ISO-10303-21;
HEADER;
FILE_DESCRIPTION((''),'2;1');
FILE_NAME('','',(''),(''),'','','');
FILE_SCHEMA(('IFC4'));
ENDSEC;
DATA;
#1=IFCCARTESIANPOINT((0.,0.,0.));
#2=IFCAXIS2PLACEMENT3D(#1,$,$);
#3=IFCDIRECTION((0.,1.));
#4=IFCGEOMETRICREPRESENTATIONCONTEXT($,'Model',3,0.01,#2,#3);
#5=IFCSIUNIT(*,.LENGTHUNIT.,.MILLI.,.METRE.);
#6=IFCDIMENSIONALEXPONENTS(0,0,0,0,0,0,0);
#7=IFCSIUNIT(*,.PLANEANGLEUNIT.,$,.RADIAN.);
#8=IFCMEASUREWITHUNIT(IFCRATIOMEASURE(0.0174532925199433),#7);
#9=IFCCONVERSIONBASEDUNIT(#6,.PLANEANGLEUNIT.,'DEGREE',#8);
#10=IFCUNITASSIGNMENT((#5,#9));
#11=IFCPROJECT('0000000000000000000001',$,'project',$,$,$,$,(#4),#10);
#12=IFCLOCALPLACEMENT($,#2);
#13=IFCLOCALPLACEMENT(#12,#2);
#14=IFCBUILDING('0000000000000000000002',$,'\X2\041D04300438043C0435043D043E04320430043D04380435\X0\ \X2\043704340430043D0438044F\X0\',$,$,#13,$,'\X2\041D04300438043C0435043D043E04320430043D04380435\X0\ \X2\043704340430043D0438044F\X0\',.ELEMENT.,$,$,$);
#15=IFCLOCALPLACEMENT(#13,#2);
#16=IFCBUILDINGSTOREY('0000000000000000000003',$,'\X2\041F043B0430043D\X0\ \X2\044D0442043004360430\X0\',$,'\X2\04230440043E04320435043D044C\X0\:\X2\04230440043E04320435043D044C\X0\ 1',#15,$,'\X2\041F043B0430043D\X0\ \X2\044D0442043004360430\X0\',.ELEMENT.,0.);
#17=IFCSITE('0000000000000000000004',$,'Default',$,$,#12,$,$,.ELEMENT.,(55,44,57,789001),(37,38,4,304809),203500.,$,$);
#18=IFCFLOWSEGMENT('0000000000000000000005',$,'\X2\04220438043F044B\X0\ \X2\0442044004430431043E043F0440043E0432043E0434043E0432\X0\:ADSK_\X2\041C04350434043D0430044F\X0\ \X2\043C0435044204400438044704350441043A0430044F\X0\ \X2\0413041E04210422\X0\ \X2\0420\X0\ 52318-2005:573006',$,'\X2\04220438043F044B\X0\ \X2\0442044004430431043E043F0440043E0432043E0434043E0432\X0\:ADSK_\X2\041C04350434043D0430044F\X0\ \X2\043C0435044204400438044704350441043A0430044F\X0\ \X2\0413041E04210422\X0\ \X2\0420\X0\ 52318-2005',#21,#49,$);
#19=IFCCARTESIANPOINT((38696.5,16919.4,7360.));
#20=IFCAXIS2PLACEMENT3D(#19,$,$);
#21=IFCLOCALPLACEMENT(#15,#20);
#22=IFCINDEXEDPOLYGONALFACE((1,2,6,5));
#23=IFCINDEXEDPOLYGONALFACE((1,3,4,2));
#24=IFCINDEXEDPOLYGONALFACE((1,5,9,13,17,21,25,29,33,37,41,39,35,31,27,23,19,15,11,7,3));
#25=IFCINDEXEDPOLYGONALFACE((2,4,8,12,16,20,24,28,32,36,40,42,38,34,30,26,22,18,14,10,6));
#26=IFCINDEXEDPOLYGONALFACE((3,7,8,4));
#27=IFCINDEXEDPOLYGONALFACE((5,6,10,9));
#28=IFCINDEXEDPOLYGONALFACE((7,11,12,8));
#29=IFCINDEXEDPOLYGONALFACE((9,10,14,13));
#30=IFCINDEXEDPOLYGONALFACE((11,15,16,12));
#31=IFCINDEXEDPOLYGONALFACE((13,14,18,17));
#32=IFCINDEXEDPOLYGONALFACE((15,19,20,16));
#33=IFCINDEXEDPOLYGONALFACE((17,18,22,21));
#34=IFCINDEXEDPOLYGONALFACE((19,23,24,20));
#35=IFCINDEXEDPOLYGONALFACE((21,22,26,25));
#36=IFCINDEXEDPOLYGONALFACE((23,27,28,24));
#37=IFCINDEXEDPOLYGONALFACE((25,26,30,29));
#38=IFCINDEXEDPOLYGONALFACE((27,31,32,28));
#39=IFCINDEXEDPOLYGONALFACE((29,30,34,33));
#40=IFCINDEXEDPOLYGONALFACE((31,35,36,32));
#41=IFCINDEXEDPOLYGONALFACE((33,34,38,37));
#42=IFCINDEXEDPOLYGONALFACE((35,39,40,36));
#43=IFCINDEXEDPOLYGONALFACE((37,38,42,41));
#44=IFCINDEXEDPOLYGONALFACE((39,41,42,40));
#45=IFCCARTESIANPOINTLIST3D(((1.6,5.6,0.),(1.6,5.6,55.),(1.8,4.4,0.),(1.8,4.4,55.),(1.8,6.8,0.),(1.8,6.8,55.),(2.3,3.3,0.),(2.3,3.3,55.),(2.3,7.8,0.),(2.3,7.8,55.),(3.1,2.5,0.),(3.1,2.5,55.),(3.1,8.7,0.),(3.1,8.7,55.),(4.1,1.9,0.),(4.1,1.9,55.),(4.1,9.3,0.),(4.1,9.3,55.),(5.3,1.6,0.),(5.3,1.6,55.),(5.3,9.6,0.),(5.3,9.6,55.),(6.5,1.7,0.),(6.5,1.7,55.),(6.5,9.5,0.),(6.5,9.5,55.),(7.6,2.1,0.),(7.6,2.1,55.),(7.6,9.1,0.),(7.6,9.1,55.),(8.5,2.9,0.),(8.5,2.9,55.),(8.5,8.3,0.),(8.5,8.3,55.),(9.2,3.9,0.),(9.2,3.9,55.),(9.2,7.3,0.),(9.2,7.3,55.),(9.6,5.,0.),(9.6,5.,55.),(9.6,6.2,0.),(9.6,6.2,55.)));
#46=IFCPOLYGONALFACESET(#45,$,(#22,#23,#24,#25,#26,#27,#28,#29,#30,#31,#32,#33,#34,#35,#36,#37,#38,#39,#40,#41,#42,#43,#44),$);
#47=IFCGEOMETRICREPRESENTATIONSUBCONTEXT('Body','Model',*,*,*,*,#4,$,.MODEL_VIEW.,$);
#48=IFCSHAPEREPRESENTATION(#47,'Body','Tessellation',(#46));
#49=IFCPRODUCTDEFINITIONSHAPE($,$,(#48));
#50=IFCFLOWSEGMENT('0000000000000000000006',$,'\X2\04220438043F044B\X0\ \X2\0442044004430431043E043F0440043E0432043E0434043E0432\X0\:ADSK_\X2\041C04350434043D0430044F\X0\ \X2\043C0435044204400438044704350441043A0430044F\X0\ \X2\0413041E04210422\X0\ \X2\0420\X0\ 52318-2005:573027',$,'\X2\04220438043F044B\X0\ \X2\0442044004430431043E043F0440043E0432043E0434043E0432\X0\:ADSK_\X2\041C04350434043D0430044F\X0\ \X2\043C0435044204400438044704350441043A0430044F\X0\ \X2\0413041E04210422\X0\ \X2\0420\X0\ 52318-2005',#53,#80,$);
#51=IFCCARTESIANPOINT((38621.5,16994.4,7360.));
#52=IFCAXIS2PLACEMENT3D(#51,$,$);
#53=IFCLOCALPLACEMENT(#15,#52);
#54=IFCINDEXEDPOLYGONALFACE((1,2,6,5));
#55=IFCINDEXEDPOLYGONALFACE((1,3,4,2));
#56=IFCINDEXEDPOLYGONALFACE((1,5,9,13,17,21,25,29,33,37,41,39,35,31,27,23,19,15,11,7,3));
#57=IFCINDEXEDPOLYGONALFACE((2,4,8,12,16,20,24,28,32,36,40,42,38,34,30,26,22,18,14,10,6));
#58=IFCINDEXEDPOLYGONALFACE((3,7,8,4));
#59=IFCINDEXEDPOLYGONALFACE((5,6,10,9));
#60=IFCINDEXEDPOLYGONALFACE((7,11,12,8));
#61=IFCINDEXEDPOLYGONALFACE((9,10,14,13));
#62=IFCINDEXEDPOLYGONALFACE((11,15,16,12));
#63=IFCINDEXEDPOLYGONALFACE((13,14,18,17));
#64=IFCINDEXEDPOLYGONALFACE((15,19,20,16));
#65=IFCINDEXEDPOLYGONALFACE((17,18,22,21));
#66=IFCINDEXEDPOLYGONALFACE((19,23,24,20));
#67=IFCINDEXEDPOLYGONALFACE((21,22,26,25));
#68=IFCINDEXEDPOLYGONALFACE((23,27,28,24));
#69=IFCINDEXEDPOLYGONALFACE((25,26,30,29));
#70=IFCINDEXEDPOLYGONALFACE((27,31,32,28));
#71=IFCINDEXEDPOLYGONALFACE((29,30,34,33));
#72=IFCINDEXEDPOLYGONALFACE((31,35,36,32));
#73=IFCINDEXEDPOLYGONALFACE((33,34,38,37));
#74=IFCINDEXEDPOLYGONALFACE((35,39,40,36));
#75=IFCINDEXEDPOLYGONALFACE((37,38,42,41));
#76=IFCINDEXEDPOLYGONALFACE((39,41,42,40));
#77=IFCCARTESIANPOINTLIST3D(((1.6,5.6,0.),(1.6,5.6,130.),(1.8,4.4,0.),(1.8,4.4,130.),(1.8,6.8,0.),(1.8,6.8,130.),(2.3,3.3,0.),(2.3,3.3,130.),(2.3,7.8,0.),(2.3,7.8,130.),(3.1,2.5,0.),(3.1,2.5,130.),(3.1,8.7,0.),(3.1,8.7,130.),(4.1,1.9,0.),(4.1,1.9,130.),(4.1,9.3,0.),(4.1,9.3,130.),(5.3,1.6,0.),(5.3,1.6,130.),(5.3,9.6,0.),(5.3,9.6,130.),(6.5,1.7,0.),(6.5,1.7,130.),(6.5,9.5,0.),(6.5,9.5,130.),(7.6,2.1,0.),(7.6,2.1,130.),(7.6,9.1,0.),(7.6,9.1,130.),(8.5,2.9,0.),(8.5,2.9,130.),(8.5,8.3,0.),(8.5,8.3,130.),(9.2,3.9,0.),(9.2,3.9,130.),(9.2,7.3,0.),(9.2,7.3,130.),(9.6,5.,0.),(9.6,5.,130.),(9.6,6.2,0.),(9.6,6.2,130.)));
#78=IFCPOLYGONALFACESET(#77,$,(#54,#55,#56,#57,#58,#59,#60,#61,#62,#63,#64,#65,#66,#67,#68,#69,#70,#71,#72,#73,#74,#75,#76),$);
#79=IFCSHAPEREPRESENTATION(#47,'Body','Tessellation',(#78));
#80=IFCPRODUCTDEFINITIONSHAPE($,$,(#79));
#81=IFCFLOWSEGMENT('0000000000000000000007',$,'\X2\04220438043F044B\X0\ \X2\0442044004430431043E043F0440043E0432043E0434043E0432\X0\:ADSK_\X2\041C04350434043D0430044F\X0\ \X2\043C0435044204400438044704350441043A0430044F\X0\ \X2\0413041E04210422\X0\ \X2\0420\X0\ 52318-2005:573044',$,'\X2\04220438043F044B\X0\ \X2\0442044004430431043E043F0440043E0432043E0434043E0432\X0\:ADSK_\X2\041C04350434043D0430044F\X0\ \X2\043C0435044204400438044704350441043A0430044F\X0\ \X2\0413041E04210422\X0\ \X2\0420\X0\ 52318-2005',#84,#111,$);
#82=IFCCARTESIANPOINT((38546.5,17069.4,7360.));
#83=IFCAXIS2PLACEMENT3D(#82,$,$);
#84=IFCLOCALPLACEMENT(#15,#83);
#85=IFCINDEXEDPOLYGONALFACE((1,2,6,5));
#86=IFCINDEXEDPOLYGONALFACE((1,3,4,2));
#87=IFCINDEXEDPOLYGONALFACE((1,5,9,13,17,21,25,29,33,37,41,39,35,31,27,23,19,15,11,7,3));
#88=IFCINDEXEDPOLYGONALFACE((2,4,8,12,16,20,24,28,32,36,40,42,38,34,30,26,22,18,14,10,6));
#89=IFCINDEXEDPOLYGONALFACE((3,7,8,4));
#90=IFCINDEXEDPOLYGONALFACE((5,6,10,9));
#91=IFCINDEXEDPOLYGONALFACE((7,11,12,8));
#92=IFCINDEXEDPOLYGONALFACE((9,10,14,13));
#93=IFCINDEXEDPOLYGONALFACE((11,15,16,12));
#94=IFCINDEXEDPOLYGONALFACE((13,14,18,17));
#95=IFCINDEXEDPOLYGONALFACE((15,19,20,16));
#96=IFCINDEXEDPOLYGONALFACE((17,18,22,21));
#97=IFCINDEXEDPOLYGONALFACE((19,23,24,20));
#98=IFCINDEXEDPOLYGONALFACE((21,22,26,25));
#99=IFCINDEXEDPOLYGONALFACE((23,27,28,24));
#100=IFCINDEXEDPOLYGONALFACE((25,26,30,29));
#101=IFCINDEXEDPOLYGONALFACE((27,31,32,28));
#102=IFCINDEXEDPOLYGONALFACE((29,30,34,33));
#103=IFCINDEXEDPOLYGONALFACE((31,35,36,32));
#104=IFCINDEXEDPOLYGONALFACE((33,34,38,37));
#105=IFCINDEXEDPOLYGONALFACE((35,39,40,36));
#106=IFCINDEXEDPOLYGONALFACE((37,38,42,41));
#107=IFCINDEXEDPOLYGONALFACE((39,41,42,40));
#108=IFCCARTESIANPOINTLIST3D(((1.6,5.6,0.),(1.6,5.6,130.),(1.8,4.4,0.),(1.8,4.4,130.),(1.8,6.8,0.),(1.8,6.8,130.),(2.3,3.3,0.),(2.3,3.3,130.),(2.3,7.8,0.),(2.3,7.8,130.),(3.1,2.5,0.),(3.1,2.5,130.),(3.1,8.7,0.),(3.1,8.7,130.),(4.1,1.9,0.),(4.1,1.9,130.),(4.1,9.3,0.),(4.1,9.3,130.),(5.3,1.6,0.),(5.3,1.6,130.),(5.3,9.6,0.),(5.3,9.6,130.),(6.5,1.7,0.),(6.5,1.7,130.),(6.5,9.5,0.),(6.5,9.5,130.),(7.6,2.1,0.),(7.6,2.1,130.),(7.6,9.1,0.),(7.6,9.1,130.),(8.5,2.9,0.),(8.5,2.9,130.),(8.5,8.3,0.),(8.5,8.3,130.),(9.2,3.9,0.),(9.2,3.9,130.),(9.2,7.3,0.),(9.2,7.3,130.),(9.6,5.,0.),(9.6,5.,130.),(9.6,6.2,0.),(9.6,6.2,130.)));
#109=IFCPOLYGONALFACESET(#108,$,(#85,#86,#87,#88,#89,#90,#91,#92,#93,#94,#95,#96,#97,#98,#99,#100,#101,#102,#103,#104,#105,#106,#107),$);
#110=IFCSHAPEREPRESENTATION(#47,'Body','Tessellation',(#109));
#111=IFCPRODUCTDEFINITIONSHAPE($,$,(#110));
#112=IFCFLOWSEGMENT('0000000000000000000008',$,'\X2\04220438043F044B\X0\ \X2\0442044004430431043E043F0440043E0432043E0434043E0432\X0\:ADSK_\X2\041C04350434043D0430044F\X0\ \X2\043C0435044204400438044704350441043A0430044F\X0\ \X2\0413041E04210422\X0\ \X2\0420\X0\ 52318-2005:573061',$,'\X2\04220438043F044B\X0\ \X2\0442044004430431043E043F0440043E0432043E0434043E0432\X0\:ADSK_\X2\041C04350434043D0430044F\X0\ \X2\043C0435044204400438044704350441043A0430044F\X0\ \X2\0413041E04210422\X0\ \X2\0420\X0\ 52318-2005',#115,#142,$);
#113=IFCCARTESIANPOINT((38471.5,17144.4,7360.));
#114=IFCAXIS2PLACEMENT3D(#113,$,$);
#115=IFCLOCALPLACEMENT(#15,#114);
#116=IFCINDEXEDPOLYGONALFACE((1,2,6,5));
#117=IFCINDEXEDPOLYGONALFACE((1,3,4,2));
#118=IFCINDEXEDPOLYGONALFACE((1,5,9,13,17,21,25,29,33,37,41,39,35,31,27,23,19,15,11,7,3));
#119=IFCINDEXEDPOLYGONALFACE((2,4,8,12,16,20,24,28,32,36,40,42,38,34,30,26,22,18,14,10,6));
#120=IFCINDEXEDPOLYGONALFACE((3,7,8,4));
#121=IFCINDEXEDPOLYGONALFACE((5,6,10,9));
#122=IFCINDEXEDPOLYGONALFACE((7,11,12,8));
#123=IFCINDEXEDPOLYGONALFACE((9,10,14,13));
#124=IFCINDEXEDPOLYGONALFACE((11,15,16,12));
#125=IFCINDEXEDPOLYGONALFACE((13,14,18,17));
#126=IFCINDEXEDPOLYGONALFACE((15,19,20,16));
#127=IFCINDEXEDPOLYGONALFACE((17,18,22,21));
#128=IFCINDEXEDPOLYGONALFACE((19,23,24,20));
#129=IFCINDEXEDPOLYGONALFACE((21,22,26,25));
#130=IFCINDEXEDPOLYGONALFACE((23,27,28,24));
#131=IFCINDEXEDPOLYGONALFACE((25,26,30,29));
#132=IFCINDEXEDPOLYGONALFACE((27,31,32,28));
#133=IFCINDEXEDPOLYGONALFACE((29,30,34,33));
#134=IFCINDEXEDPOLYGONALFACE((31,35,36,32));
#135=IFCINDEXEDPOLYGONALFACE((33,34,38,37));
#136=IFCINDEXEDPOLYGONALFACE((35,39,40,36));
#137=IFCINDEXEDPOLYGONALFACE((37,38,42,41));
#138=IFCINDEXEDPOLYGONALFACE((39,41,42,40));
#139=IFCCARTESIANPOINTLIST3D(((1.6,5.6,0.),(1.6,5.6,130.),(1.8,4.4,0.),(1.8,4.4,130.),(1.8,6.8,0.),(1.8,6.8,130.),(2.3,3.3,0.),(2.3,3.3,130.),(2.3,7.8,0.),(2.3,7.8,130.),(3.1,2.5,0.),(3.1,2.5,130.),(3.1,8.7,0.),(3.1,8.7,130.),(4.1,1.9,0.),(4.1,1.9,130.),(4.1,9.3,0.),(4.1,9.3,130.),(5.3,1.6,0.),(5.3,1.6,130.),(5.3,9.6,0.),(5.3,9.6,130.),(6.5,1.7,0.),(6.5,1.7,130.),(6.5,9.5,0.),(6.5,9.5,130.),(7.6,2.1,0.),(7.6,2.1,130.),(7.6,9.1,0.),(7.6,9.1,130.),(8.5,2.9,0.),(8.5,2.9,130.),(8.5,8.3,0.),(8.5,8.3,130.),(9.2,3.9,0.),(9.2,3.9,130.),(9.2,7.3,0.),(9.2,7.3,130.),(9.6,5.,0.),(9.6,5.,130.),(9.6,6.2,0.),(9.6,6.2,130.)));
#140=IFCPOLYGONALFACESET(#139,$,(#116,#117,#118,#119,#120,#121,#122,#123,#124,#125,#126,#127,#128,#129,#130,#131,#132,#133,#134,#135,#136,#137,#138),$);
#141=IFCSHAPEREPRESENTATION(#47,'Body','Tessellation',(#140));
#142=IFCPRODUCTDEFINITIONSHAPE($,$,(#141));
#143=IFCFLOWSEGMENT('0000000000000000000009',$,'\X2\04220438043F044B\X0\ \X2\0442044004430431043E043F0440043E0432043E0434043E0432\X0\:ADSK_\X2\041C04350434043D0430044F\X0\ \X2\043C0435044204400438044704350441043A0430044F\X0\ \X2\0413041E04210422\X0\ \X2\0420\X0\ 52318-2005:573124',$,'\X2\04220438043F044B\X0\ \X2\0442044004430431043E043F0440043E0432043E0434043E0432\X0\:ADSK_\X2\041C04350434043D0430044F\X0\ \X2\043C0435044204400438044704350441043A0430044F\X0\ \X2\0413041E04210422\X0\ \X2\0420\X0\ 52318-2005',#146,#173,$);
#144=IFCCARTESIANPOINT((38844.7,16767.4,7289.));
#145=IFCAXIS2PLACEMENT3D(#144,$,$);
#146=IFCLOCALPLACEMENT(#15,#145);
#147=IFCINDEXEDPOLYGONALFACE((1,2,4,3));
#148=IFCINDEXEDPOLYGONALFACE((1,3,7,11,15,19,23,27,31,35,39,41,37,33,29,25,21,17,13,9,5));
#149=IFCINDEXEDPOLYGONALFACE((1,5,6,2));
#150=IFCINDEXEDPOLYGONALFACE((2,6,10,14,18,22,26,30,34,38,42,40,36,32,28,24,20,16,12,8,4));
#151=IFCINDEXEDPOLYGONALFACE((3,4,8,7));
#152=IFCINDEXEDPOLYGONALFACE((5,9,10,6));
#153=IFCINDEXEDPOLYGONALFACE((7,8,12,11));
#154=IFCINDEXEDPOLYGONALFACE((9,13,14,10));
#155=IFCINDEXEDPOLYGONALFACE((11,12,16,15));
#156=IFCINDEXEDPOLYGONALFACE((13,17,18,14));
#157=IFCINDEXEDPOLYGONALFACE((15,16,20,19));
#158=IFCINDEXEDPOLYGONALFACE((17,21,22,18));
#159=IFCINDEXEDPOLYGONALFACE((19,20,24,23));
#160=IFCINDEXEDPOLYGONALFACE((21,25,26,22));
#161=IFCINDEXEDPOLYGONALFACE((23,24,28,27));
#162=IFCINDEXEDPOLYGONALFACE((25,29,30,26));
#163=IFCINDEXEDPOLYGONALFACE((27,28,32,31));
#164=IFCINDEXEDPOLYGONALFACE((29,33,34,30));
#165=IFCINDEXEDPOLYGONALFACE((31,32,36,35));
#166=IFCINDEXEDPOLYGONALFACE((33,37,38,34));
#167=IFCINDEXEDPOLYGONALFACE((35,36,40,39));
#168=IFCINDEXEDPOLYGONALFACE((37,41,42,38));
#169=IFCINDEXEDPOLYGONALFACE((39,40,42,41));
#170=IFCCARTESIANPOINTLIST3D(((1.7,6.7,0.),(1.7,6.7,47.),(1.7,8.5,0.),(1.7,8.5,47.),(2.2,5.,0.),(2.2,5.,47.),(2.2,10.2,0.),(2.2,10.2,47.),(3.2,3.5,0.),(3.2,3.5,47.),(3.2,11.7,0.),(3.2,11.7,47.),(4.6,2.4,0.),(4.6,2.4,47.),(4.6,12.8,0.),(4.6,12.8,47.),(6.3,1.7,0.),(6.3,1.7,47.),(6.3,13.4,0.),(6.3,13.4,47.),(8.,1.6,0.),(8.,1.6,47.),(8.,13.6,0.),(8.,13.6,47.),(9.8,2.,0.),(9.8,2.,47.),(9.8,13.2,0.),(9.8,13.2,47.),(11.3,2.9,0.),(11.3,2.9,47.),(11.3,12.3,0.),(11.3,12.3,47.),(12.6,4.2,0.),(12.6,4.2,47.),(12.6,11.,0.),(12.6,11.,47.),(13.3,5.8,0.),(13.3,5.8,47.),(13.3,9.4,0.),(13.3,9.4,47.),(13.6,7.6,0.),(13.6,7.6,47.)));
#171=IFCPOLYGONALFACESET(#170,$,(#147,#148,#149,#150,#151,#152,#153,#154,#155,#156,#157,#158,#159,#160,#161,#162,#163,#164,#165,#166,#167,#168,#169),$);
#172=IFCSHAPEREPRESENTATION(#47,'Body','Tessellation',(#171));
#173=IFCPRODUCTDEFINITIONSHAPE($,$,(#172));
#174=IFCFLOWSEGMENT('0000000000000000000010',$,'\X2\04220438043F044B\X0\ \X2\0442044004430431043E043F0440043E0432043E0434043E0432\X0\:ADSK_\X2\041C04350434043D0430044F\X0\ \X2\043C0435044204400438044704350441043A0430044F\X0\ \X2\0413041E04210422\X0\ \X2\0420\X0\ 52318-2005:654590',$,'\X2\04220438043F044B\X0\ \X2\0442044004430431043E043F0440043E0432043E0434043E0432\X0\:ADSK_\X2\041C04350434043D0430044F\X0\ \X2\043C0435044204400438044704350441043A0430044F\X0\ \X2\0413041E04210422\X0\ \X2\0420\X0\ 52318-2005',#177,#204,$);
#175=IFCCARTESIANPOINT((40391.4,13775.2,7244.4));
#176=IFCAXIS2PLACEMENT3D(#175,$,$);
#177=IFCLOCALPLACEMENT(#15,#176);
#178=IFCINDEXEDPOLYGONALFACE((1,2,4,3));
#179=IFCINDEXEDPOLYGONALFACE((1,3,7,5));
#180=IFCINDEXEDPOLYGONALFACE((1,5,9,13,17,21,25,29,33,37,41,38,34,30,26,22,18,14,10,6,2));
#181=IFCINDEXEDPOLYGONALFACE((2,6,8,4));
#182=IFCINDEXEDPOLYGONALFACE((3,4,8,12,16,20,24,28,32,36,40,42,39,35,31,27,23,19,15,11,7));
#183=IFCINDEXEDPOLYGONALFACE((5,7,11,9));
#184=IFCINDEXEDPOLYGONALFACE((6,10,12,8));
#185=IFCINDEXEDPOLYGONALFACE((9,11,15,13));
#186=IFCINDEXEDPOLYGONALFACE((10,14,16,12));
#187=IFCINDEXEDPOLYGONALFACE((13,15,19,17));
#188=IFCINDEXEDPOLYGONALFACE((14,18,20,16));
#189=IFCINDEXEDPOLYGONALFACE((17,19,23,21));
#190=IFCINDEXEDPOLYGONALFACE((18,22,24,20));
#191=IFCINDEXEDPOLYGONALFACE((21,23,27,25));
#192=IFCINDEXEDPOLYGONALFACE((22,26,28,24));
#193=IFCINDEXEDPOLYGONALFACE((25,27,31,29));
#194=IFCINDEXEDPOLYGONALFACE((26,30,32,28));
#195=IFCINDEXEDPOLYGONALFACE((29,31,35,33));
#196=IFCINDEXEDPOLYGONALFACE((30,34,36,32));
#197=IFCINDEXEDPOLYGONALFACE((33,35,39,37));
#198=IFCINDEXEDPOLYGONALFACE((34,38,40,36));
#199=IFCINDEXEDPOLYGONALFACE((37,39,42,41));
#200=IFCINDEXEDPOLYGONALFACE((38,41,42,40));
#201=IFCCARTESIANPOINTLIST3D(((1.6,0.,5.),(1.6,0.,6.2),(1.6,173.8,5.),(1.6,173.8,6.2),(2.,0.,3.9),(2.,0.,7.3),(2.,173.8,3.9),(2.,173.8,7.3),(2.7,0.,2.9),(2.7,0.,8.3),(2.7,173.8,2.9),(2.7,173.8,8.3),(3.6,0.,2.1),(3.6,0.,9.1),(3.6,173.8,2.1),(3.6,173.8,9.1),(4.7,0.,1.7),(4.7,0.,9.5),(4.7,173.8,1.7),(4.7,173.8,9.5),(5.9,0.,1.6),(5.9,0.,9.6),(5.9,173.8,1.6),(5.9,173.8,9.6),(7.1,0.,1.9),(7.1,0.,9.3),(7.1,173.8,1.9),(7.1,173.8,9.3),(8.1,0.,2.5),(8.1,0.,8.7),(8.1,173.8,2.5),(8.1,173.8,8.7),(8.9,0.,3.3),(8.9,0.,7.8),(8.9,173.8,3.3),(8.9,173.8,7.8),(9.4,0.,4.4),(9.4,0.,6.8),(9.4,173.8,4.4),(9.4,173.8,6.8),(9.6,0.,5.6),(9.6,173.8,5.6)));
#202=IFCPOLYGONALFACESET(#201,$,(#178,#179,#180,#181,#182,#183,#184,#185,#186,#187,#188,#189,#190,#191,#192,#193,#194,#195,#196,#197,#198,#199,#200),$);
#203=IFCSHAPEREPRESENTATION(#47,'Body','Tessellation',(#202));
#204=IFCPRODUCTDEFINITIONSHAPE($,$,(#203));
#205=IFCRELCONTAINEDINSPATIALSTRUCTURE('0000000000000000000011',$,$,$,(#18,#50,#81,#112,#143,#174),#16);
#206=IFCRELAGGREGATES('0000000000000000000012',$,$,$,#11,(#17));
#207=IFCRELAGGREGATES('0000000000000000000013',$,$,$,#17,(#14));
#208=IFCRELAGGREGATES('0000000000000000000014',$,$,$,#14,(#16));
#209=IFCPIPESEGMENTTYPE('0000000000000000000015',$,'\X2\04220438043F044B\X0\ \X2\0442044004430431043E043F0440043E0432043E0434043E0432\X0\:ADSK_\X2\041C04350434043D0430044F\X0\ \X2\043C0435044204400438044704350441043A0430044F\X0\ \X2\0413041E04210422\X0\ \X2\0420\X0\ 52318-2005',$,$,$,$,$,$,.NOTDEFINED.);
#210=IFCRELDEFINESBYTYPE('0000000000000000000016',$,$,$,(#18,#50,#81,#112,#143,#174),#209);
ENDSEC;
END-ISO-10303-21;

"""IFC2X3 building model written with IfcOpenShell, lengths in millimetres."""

from ifc_helpers import new_model, entity, si_unit, converted_unit, direction, frame, frame_2d, origin, origin_2d_with_axis, place, context, subcontext, project, spatial, circle, extrude, type_object, element, save


model = new_model("IFC2X3")

# Units and contexts
model_context = context("Model", 3, precision=0.01, world=origin(), true_north=direction((0.0, 1.0)))
body_context = subcontext(model_context, "Body", "Model", "MODEL_VIEW")
ifc_project = project(units=[si_unit("LENGTHUNIT", "METRE", prefix="MILLI"), converted_unit("PLANEANGLEUNIT", "DEGREE", entity("IfcRatioMeasure", 0.0174532925199433), si_unit("PLANEANGLEUNIT", "RADIAN"), dimensions=[0, 0, 0, 0, 0, 0, 0])], contexts=[model_context])

# Site, building, storey
site_placement = place(None, frame((0.0, 0.0, 0.0)))
site = spatial("IfcSite", under=ifc_project, at=site_placement, Name="Default", CompositionType="ELEMENT", RefLatitude=(55, 44, 57, 789001), RefLongitude=(37, 38, 4, 304809), RefElevation=203500.0)
building_placement = place(site_placement, origin())
building = spatial("IfcBuilding", under=site, at=building_placement, Name="Наименование здания", LongName="Наименование здания", CompositionType="ELEMENT")
storey_placement = place(building_placement, origin())
storey = spatial("IfcBuildingStorey", under=building, at=storey_placement, Name="План этажа", ObjectType="Уровень:Уровень 1", LongName="План этажа", CompositionType="ELEMENT", Elevation=0.0)

# Flow segments
pipe_segment_type = type_object("IfcPipeSegmentType", Name="Типы трубопроводов:ADSK_Медная метрическая ГОСТ Р 52318-2005", PredefinedType="NOTDEFINED")
flow_segment_1_placement = place(storey_placement, frame((38696.5, 16919.4, 7360.0)))
element("IfcFlowSegment", 1, at=flow_segment_1_placement, inside=storey, type_object=pipe_segment_type, Name="Типы трубопроводов:ADSK_Медная метрическая ГОСТ Р 52318-2005:573006", ObjectType="Типы трубопроводов:ADSK_Медная метрическая ГОСТ Р 52318-2005", context=body_context, shape_type="SweptSolid", body=[
    extrude(circle(Radius=4.0, at=origin_2d_with_axis()), frame((5.6, 5.6, 0.0), z_axis=(0.0, 0.0, 1.0), x_axis=(-1.0, 0.0, 0.0)), (0.0, 0.0, 1.0), 55.0),
])
flow_segment_2_placement = place(storey_placement, frame((38621.5, 16994.4, 7360.0)))
element("IfcFlowSegment", 2, at=flow_segment_2_placement, inside=storey, type_object=pipe_segment_type, Name="Типы трубопроводов:ADSK_Медная метрическая ГОСТ Р 52318-2005:573027", ObjectType="Типы трубопроводов:ADSK_Медная метрическая ГОСТ Р 52318-2005", context=body_context, shape_type="SweptSolid", body=[
    extrude(circle(Radius=4.0, at=origin_2d_with_axis()), frame((5.6, 5.6, 0.0), z_axis=(0.0, 0.0, 1.0), x_axis=(-1.0, 0.0, 0.0)), (0.0, 0.0, 1.0), 130.0),
])
flow_segment_3_placement = place(storey_placement, frame((38546.5, 17069.4, 7360.0)))
element("IfcFlowSegment", 3, at=flow_segment_3_placement, inside=storey, type_object=pipe_segment_type, Name="Типы трубопроводов:ADSK_Медная метрическая ГОСТ Р 52318-2005:573044", ObjectType="Типы трубопроводов:ADSK_Медная метрическая ГОСТ Р 52318-2005", context=body_context, shape_type="SweptSolid", body=[
    extrude(circle(Radius=4.0, at=origin_2d_with_axis()), frame((5.6, 5.6, 0.0), z_axis=(0.0, 0.0, 1.0), x_axis=(-1.0, 0.0, 0.0)), (0.0, 0.0, 1.0), 130.0),
])
flow_segment_4_placement = place(storey_placement, frame((38471.5, 17144.4, 7360.0)))
element("IfcFlowSegment", 4, at=flow_segment_4_placement, inside=storey, type_object=pipe_segment_type, Name="Типы трубопроводов:ADSK_Медная метрическая ГОСТ Р 52318-2005:573061", ObjectType="Типы трубопроводов:ADSK_Медная метрическая ГОСТ Р 52318-2005", context=body_context, shape_type="SweptSolid", body=[
    extrude(circle(Radius=4.0, at=origin_2d_with_axis()), frame((5.6, 5.6, 0.0), z_axis=(0.0, 0.0, 1.0), x_axis=(-1.0, 0.0, 0.0)), (0.0, 0.0, 1.0), 130.0),
])
flow_segment_5_placement = place(storey_placement, frame((38844.7, 16767.4, 7289.0)))
element("IfcFlowSegment", 5, at=flow_segment_5_placement, inside=storey, type_object=pipe_segment_type, Name="Типы трубопроводов:ADSK_Медная метрическая ГОСТ Р 52318-2005:573124", ObjectType="Типы трубопроводов:ADSK_Медная метрическая ГОСТ Р 52318-2005", context=body_context, shape_type="SweptSolid", body=[
    extrude(circle(Radius=6.0, at=frame_2d((0.0, 0.0), x_axis=(1.0, 0.0))), frame((7.6, 7.6, 0.0)), (0.0, 0.0, 1.0), 47.0),
])
flow_segment_6_placement = place(storey_placement, frame((40391.4, 13775.2, 7244.4)))
element("IfcFlowSegment", 6, at=flow_segment_6_placement, inside=storey, type_object=pipe_segment_type, Name="Типы трубопроводов:ADSK_Медная метрическая ГОСТ Р 52318-2005:654590", ObjectType="Типы трубопроводов:ADSK_Медная метрическая ГОСТ Р 52318-2005", context=body_context, shape_type="SweptSolid", body=[
    extrude(circle(Radius=4.0, at=frame_2d((0.0, 0.0), x_axis=(1.0, 0.0))), frame((5.6, 0.0, 5.6), z_axis=(0.0, 1.0, 0.0), x_axis=(1.0, 0.0, 0.0)), (0.0, 0.0, 1.0), 173.8),
])

save(model, "model.ifc")
